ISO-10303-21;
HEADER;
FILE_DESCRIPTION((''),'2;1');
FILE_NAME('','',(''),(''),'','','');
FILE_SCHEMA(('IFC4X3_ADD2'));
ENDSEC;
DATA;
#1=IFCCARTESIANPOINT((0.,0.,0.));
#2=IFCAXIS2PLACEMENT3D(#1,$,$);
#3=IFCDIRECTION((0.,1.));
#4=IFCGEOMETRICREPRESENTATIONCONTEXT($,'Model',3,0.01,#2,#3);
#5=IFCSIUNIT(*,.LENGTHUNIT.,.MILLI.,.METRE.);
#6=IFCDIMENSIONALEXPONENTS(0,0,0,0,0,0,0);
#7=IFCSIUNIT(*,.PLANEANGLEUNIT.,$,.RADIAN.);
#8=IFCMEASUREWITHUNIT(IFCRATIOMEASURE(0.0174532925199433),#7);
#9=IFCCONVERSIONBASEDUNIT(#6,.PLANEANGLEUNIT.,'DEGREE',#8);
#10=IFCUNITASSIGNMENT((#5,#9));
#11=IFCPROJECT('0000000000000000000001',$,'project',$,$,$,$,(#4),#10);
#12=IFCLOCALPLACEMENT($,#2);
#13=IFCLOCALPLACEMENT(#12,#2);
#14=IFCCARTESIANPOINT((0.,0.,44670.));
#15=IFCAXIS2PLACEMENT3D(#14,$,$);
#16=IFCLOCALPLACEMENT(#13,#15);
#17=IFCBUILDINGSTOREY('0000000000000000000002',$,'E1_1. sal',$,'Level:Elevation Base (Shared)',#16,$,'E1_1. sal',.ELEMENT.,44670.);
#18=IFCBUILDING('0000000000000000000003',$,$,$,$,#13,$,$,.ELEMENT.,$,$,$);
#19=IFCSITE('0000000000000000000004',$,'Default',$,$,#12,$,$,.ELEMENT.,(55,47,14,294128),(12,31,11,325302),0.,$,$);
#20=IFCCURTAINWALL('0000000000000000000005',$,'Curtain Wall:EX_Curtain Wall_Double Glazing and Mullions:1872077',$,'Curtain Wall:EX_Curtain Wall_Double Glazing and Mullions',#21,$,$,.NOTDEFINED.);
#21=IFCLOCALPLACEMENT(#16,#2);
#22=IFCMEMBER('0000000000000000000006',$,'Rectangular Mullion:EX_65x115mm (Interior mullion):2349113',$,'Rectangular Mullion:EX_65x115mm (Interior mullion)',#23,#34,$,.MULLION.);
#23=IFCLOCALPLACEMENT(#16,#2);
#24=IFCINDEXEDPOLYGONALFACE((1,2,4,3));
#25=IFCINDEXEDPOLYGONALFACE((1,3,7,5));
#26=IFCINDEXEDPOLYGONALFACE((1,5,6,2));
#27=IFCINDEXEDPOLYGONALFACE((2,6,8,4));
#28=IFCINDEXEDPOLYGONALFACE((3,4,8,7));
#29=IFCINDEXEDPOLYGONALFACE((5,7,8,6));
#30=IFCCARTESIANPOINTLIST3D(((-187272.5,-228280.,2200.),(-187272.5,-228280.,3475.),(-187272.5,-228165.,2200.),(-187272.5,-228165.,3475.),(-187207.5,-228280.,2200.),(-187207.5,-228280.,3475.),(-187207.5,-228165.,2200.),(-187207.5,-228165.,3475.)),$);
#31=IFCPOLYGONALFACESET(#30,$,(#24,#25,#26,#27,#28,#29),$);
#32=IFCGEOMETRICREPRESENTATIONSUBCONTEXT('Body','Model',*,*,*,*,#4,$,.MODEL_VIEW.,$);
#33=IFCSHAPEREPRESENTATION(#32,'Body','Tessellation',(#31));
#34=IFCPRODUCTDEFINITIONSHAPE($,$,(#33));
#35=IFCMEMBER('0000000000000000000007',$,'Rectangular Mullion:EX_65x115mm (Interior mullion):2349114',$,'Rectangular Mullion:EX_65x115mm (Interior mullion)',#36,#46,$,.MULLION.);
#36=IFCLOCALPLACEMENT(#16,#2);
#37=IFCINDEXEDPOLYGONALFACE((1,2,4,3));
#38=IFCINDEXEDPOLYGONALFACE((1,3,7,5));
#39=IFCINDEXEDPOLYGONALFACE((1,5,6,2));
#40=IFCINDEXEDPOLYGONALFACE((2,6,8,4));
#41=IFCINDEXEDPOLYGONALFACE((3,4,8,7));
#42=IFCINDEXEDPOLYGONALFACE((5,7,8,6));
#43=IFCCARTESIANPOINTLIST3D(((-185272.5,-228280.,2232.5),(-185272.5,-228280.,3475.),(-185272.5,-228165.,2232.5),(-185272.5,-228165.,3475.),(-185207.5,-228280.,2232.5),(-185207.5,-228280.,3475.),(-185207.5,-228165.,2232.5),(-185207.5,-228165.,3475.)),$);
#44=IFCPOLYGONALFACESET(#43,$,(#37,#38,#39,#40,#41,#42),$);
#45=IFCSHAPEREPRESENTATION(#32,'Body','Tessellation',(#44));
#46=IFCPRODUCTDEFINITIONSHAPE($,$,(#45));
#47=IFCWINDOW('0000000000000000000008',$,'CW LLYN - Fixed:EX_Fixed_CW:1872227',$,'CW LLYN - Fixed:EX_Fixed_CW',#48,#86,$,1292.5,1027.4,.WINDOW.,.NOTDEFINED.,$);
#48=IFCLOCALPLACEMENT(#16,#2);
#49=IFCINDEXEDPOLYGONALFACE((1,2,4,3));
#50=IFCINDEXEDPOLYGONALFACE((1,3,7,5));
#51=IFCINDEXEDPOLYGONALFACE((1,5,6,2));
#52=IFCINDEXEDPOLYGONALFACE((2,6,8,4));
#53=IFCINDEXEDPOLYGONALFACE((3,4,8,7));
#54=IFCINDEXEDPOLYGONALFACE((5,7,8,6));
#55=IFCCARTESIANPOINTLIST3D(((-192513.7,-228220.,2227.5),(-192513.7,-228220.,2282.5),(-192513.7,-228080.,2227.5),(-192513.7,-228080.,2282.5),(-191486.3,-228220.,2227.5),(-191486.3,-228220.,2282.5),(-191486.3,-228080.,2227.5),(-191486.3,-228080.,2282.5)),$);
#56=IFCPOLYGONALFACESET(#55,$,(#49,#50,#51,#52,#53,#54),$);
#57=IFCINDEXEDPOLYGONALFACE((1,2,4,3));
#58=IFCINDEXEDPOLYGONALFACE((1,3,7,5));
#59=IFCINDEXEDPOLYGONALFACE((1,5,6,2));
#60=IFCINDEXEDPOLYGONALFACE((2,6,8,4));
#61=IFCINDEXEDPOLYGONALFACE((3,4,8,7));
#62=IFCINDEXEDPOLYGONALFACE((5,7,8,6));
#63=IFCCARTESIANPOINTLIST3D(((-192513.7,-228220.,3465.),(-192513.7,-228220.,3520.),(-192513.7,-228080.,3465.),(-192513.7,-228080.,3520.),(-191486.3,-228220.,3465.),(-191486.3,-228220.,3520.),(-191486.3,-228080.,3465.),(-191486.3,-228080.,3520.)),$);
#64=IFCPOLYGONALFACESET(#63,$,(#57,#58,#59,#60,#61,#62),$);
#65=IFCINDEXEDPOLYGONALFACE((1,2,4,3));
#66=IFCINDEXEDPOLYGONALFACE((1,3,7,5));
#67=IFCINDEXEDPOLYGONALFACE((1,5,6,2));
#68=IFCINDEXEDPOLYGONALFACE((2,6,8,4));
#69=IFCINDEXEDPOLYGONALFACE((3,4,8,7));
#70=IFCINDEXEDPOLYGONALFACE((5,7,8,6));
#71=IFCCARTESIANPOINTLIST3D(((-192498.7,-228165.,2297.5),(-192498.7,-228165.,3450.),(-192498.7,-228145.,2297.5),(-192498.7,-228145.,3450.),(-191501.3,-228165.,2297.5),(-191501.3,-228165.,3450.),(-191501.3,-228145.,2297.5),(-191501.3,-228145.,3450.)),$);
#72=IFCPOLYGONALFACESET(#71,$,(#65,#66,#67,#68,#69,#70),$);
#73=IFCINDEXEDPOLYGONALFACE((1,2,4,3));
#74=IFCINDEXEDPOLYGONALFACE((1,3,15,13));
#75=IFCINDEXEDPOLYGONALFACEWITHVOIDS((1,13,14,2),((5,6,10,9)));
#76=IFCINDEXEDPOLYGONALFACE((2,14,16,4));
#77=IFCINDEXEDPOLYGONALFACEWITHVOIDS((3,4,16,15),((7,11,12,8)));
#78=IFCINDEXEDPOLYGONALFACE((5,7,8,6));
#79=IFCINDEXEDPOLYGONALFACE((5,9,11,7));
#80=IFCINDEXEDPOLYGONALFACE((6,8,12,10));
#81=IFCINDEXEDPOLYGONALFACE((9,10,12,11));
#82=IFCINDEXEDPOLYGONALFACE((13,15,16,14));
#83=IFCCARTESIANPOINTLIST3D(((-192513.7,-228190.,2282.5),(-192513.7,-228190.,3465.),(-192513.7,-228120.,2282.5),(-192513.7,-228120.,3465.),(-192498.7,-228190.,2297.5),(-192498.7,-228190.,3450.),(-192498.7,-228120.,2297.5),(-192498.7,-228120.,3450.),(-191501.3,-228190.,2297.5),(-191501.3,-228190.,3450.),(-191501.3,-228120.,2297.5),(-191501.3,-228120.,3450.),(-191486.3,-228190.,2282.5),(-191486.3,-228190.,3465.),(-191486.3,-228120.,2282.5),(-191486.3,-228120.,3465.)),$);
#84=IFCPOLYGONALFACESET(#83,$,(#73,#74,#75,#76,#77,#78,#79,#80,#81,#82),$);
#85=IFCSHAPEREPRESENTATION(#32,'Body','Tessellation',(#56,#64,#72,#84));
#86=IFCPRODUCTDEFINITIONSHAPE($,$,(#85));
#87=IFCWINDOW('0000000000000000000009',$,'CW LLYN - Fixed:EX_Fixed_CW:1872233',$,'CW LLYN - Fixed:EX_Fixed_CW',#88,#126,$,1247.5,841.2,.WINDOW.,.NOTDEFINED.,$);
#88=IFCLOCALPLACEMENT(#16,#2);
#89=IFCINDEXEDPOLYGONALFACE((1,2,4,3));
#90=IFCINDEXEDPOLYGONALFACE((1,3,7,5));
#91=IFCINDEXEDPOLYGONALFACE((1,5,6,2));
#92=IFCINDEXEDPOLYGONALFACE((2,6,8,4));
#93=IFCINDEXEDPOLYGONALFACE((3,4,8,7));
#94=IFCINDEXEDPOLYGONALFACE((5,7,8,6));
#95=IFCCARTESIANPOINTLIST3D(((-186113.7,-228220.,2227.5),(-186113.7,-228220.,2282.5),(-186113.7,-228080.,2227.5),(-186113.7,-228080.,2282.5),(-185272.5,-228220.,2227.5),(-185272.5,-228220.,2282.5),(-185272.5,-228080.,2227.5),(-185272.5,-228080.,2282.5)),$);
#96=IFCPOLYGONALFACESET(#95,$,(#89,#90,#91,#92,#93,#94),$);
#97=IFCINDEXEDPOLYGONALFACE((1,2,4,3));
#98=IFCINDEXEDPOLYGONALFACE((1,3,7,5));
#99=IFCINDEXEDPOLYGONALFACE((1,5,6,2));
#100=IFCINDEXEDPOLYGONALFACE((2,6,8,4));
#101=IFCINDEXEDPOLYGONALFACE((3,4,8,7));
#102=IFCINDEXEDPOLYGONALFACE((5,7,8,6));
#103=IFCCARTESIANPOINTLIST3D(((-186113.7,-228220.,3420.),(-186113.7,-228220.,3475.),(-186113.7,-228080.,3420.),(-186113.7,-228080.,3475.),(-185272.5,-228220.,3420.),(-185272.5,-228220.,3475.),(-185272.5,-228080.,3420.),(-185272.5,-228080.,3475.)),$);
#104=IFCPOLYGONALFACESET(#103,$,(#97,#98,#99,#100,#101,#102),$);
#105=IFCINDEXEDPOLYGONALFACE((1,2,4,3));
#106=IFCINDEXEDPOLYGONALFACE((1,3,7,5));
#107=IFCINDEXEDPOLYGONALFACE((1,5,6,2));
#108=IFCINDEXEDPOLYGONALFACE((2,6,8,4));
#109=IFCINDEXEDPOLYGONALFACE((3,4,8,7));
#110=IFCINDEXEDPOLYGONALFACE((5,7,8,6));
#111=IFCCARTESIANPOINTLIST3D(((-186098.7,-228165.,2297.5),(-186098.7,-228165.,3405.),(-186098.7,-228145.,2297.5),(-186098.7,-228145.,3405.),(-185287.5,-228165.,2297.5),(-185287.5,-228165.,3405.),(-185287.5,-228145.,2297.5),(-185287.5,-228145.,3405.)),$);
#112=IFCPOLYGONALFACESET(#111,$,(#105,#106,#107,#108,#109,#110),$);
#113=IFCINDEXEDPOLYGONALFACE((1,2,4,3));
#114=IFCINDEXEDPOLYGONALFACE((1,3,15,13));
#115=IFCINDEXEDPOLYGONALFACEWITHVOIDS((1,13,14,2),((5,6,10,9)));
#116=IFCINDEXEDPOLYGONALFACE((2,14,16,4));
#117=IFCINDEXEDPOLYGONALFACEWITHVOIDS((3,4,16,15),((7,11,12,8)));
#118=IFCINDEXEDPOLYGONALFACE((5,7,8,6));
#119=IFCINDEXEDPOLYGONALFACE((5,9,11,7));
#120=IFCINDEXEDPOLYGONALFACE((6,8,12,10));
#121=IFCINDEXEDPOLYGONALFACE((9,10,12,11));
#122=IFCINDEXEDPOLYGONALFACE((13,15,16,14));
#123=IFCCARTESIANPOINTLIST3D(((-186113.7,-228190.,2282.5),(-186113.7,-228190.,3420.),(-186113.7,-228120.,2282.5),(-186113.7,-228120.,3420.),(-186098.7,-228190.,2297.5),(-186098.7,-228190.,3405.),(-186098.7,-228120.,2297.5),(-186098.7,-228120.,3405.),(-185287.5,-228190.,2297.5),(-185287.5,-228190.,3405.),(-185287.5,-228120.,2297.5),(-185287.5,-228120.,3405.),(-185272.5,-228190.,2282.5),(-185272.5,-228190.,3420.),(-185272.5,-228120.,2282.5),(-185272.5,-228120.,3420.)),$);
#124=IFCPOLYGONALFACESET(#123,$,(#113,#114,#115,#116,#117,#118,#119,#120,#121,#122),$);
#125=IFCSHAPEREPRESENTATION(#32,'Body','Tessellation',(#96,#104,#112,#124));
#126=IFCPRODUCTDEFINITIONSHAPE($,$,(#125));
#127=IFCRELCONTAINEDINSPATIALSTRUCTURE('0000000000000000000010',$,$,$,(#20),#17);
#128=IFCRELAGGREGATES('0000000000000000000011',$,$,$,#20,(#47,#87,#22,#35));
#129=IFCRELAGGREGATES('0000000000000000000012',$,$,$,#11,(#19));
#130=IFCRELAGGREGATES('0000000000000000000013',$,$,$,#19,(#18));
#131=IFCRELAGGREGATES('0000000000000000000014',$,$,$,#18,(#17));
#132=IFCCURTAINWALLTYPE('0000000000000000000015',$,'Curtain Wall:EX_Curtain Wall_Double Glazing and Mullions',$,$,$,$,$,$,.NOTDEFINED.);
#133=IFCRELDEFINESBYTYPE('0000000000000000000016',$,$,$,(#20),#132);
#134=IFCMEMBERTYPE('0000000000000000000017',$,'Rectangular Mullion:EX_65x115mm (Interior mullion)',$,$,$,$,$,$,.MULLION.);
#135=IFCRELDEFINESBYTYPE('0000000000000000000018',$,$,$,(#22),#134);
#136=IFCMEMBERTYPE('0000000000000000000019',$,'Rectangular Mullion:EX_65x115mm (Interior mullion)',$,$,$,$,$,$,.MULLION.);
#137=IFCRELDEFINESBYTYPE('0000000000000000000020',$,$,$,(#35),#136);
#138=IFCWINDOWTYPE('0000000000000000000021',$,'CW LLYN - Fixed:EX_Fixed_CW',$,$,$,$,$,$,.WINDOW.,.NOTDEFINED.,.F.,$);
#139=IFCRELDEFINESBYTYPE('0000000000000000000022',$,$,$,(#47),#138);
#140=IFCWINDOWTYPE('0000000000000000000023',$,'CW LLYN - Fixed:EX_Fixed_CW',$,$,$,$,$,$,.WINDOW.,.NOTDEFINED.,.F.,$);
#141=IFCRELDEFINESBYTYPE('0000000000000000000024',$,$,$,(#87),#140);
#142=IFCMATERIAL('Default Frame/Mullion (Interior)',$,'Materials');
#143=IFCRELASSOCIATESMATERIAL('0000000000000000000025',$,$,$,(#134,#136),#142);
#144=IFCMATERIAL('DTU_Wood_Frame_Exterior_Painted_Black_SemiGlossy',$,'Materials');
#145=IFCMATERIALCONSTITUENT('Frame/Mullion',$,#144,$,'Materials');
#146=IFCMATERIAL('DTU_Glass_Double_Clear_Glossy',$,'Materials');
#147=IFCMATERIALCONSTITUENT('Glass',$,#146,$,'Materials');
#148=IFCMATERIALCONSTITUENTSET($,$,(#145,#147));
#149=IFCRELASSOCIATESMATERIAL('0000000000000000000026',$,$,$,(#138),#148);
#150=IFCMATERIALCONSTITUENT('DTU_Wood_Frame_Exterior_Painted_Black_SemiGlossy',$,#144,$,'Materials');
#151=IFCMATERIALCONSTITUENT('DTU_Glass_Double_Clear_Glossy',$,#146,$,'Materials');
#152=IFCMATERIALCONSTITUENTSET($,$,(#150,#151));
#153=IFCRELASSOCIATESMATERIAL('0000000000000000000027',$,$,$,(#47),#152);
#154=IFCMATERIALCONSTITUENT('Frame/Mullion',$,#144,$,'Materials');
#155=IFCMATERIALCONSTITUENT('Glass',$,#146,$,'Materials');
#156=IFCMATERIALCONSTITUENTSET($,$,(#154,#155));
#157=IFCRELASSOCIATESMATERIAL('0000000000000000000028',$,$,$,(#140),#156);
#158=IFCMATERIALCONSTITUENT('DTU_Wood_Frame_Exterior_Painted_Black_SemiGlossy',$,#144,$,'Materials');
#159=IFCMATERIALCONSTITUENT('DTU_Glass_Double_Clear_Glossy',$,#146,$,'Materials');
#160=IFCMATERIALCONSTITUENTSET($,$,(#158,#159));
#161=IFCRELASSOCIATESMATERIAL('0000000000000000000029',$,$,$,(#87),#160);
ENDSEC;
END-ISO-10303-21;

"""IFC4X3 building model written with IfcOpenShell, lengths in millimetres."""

from ifc_helpers import new_model, entity, si_unit, converted_unit, direction, frame, frame_2d, origin, origin_2d_with_axis, place, context, subcontext, project, spatial, polyline, rectangle, outline, extrude, source, transform, mapped, material, constituent, constituent_set, material_profile, profile_set, type_object, type_shapes, element, aggregate, save


model = new_model("IFC4X3")

# Units and contexts
model_context = context("Model", 3, precision=0.01, world=origin(), true_north=direction((0.0, 1.0)))
body_context = subcontext(model_context, "Body", "Model", "MODEL_VIEW")
ifc_project = project(units=[si_unit("LENGTHUNIT", "METRE", prefix="MILLI"), converted_unit("PLANEANGLEUNIT", "DEGREE", entity("IfcRatioMeasure", 0.0174532925199433), si_unit("PLANEANGLEUNIT", "RADIAN"), dimensions=[0, 0, 0, 0, 0, 0, 0])], contexts=[model_context])

# Site, building, storey
site_placement = place(None, origin())
site = spatial("IfcSite", under=ifc_project, at=site_placement, Name="Default", CompositionType="ELEMENT", RefLatitude=(55, 47, 14, 294128), RefLongitude=(12, 31, 11, 325302), RefElevation=0.0)
building_placement = place(site_placement, origin())
building = spatial("IfcBuilding", under=site, at=building_placement, CompositionType="ELEMENT")
storey_placement = place(building_placement, frame((0.0, 0.0, 44670.0)))
storey = spatial("IfcBuildingStorey", under=building, at=storey_placement, Name="E1_1. sal", ObjectType="Level:Elevation Base (Shared)", LongName="E1_1. sal", CompositionType="ELEMENT", Elevation=44670.0)

# Curtain wall, members, windows
curtain_wall_type = type_object("IfcCurtainWallType", Name="Curtain Wall:EX_Curtain Wall_Double Glazing and Mullions", PredefinedType="NOTDEFINED")
curtain_wall_placement = place(storey_placement, frame((0.0, 0.0, -44670.0)))
curtain_wall = element("IfcCurtainWall", 1, at=curtain_wall_placement, inside=storey, type_object=curtain_wall_type, Name="Curtain Wall:EX_Curtain Wall_Double Glazing and Mullions:1872077", ObjectType="Curtain Wall:EX_Curtain Wall_Double Glazing and Mullions", PredefinedType="NOTDEFINED")
ifc_material_1 = material(Name="Default Frame/Mullion (Interior)", Category="Materials")
ifc_material_profile_1 = material_profile(ifc_material_1, rectangle(XDim=115.0, YDim=65.0, at=origin_2d_with_axis()), Name="EX_65x115mm (Interior mullion)")
ifc_profile_set_1 = profile_set([ifc_material_profile_1], Name="EX_65x115mm (Interior mullion)")
member_type_1 = type_object("IfcMemberType", Name="Rectangular Mullion:EX_65x115mm (Interior mullion)", PredefinedType="MULLION", material=ifc_profile_set_1)
shared_shape_1 = source(origin(), body_context, "Body", "SweptSolid", [
    extrude(rectangle(XDim=115.0, YDim=65.0, at=origin_2d_with_axis()), frame((0.0, -57.5, -1275.0), z_axis=(0.0, 0.0, 1.0), x_axis=(0.0, -1.0, 0.0)), (0.0, 0.0, 1.0), 1275.0),
])
type_shapes(member_type_1, [shared_shape_1])
member_1_placement = place(curtain_wall_placement, frame((-187240.0, -228280.0, 46870.0), z_axis=(0.0, 0.0, -1.0), x_axis=(1.0, 0.0, 0.0)))
member_1 = element("IfcMember", 2, at=member_1_placement, type_object=member_type_1, Name="Rectangular Mullion:EX_65x115mm (Interior mullion):2349113", ObjectType="Rectangular Mullion:EX_65x115mm (Interior mullion)", PredefinedType="MULLION", context=body_context, shape_type="MappedRepresentation", body=[
    mapped(shared_shape_1, transform((0.0, 0.0, 0.0), scale=1.0)),
])
member_type_2 = type_object("IfcMemberType", Name="Rectangular Mullion:EX_65x115mm (Interior mullion)", PredefinedType="MULLION", material=ifc_profile_set_1)
shared_shape_2 = source(origin(), body_context, "Body", "SweptSolid", [
    extrude(rectangle(XDim=115.0, YDim=65.0, at=origin_2d_with_axis()), frame((0.0, -57.5, -1242.5), z_axis=(0.0, 0.0, 1.0), x_axis=(0.0, -1.0, 0.0)), (0.0, 0.0, 1.0), 1242.5),
])
type_shapes(member_type_2, [shared_shape_2])
member_2_placement = place(curtain_wall_placement, frame((-185240.0, -228280.0, 46902.5), z_axis=(0.0, 0.0, -1.0), x_axis=(1.0, 0.0, 0.0)))
member_2 = element("IfcMember", 3, at=member_2_placement, type_object=member_type_2, Name="Rectangular Mullion:EX_65x115mm (Interior mullion):2349114", ObjectType="Rectangular Mullion:EX_65x115mm (Interior mullion)", PredefinedType="MULLION", context=body_context, shape_type="MappedRepresentation", body=[
    mapped(shared_shape_2, transform((0.0, 0.0, 0.0), scale=1.0)),
])
ifc_material_2 = material(Name="DTU_Wood_Frame_Exterior_Painted_Black_SemiGlossy", Category="Materials")
ifc_constituent_1 = constituent(ifc_material_2, Name="DTU_Wood_Frame_Exterior_Painted_Black_SemiGlossy", Category="Materials")
ifc_material_3 = material(Name="DTU_Glass_Double_Clear_Glossy", Category="Materials")
ifc_constituent_2 = constituent(ifc_material_3, Name="DTU_Glass_Double_Clear_Glossy", Category="Materials")
ifc_constituent_set_1 = constituent_set(constituents=[ifc_constituent_1, ifc_constituent_2])
ifc_constituent_3 = constituent(ifc_material_2, Name="Frame/Mullion", Category="Materials")
ifc_constituent_4 = constituent(ifc_material_3, Name="Glass", Category="Materials")
ifc_constituent_set_2 = constituent_set(constituents=[ifc_constituent_3, ifc_constituent_4])
window_type_1 = type_object("IfcWindowType", Name="CW LLYN - Fixed:EX_Fixed_CW", ParameterTakesPrecedence=False, PartitioningType="NOTDEFINED", PredefinedType="WINDOW", material=ifc_constituent_set_2)
shared_shape_3 = source(origin(), body_context, "Body", "SweptSolid", [
    extrude(rectangle(XDim=140.0, YDim=1027.4, at=origin_2d_with_axis()), frame((0.0, -130.0, 0.0), z_axis=(0.0, 0.0, 1.0), x_axis=(0.0, -1.0, 0.0)), (0.0, 0.0, 1.0), 55.0),
    extrude(rectangle(XDim=140.0, YDim=1027.4, at=frame_2d((0.0, 0.0), x_axis=(1.0, 0.0))), frame((0.0, -130.0, 1237.5), z_axis=(0.0, 0.0, 1.0), x_axis=(0.0, -1.0, 0.0)), (0.0, 0.0, 1.0), 55.0),
    extrude(rectangle(XDim=997.4, YDim=20.0, at=frame_2d((0.0, 0.0), x_axis=(1.0, 0.0))), frame((0.0, -125.0, 70.0), z_axis=(0.0, 0.0, 1.0), x_axis=(-1.0, 0.0, 0.0)), (0.0, 0.0, 1.0), 1152.5),
    extrude(outline(polyline([(-591.2, -513.7), (591.2, -513.7), (591.2, 513.7), (-591.2, 513.7), (-591.2, -513.7)]), holes=[polyline([(-576.2, 498.7), (576.2, 498.7), (576.2, -498.7), (-576.2, -498.7), (-576.2, 498.7)])]), frame((0.0, -90.0, 646.2), z_axis=(0.0, -1.0, 0.0), x_axis=(0.0, 0.0, 1.0)), (0.0, 0.0, 1.0), 70.0),
])
type_shapes(window_type_1, [shared_shape_3])
window_1_placement = place(curtain_wall_placement, frame((-192000.0, -228280.0, 46897.5), z_axis=(0.0, 0.0, 1.0), x_axis=(-1.0, 0.0, 0.0)))
window_1 = element("IfcWindow", 4, at=window_1_placement, type_object=window_type_1, material=ifc_constituent_set_1, Name="CW LLYN - Fixed:EX_Fixed_CW:1872227", ObjectType="CW LLYN - Fixed:EX_Fixed_CW", OverallHeight=1292.5, OverallWidth=1027.4, PartitioningType="NOTDEFINED", PredefinedType="WINDOW", context=body_context, shape_type="MappedRepresentation", body=[
    mapped(shared_shape_3, transform((0.0, 0.0, 0.0), scale=1.0)),
])
ifc_constituent_5 = constituent(ifc_material_2, Name="DTU_Wood_Frame_Exterior_Painted_Black_SemiGlossy", Category="Materials")
ifc_constituent_6 = constituent(ifc_material_3, Name="DTU_Glass_Double_Clear_Glossy", Category="Materials")
ifc_constituent_set_3 = constituent_set(constituents=[ifc_constituent_5, ifc_constituent_6])
ifc_constituent_7 = constituent(ifc_material_2, Name="Frame/Mullion", Category="Materials")
ifc_constituent_8 = constituent(ifc_material_3, Name="Glass", Category="Materials")
ifc_constituent_set_4 = constituent_set(constituents=[ifc_constituent_7, ifc_constituent_8])
window_type_2 = type_object("IfcWindowType", Name="CW LLYN - Fixed:EX_Fixed_CW", ParameterTakesPrecedence=False, PartitioningType="NOTDEFINED", PredefinedType="WINDOW", material=ifc_constituent_set_4)
shared_shape_4 = source(origin(), body_context, "Body", "SweptSolid", [
    extrude(rectangle(XDim=140.0, YDim=841.2, at=origin_2d_with_axis()), frame((0.0, -130.0, 0.0), z_axis=(0.0, 0.0, 1.0), x_axis=(0.0, -1.0, 0.0)), (0.0, 0.0, 1.0), 55.0),
    extrude(rectangle(XDim=140.0, YDim=841.2, at=origin_2d_with_axis()), frame((0.0, -130.0, 1192.5), z_axis=(0.0, 0.0, 1.0), x_axis=(0.0, -1.0, 0.0)), (0.0, 0.0, 1.0), 55.0),
    extrude(rectangle(XDim=811.2, YDim=20.0, at=origin_2d_with_axis()), frame((0.0, -125.0, 70.0), z_axis=(0.0, 0.0, 1.0), x_axis=(-1.0, 0.0, 0.0)), (0.0, 0.0, 1.0), 1107.5),
    extrude(outline(polyline([(-568.7, -420.6), (568.7, -420.6), (568.7, 420.6), (-568.7, 420.6), (-568.7, -420.6)]), holes=[polyline([(-553.7, 405.6), (553.7, 405.6), (553.7, -405.6), (-553.7, -405.6), (-553.7, 405.6)])]), frame((0.0, -90.0, 623.7), z_axis=(0.0, -1.0, 0.0), x_axis=(0.0, 0.0, 1.0)), (0.0, 0.0, 1.0), 70.0),
])
type_shapes(window_type_2, [shared_shape_4])
window_2_placement = place(curtain_wall_placement, frame((-185693.1, -228280.0, 46897.5), z_axis=(0.0, 0.0, 1.0), x_axis=(-1.0, 0.0, 0.0)))
window_2 = element("IfcWindow", 5, at=window_2_placement, type_object=window_type_2, material=ifc_constituent_set_3, Name="CW LLYN - Fixed:EX_Fixed_CW:1872233", ObjectType="CW LLYN - Fixed:EX_Fixed_CW", OverallHeight=1247.5, OverallWidth=841.2, PartitioningType="NOTDEFINED", PredefinedType="WINDOW", context=body_context, shape_type="MappedRepresentation", body=[
    mapped(shared_shape_4, transform((0.0, 0.0, 0.0), scale=1.0)),
])
aggregate(curtain_wall, [window_1, window_2, member_1, member_2])

save(model, "model.ifc")
